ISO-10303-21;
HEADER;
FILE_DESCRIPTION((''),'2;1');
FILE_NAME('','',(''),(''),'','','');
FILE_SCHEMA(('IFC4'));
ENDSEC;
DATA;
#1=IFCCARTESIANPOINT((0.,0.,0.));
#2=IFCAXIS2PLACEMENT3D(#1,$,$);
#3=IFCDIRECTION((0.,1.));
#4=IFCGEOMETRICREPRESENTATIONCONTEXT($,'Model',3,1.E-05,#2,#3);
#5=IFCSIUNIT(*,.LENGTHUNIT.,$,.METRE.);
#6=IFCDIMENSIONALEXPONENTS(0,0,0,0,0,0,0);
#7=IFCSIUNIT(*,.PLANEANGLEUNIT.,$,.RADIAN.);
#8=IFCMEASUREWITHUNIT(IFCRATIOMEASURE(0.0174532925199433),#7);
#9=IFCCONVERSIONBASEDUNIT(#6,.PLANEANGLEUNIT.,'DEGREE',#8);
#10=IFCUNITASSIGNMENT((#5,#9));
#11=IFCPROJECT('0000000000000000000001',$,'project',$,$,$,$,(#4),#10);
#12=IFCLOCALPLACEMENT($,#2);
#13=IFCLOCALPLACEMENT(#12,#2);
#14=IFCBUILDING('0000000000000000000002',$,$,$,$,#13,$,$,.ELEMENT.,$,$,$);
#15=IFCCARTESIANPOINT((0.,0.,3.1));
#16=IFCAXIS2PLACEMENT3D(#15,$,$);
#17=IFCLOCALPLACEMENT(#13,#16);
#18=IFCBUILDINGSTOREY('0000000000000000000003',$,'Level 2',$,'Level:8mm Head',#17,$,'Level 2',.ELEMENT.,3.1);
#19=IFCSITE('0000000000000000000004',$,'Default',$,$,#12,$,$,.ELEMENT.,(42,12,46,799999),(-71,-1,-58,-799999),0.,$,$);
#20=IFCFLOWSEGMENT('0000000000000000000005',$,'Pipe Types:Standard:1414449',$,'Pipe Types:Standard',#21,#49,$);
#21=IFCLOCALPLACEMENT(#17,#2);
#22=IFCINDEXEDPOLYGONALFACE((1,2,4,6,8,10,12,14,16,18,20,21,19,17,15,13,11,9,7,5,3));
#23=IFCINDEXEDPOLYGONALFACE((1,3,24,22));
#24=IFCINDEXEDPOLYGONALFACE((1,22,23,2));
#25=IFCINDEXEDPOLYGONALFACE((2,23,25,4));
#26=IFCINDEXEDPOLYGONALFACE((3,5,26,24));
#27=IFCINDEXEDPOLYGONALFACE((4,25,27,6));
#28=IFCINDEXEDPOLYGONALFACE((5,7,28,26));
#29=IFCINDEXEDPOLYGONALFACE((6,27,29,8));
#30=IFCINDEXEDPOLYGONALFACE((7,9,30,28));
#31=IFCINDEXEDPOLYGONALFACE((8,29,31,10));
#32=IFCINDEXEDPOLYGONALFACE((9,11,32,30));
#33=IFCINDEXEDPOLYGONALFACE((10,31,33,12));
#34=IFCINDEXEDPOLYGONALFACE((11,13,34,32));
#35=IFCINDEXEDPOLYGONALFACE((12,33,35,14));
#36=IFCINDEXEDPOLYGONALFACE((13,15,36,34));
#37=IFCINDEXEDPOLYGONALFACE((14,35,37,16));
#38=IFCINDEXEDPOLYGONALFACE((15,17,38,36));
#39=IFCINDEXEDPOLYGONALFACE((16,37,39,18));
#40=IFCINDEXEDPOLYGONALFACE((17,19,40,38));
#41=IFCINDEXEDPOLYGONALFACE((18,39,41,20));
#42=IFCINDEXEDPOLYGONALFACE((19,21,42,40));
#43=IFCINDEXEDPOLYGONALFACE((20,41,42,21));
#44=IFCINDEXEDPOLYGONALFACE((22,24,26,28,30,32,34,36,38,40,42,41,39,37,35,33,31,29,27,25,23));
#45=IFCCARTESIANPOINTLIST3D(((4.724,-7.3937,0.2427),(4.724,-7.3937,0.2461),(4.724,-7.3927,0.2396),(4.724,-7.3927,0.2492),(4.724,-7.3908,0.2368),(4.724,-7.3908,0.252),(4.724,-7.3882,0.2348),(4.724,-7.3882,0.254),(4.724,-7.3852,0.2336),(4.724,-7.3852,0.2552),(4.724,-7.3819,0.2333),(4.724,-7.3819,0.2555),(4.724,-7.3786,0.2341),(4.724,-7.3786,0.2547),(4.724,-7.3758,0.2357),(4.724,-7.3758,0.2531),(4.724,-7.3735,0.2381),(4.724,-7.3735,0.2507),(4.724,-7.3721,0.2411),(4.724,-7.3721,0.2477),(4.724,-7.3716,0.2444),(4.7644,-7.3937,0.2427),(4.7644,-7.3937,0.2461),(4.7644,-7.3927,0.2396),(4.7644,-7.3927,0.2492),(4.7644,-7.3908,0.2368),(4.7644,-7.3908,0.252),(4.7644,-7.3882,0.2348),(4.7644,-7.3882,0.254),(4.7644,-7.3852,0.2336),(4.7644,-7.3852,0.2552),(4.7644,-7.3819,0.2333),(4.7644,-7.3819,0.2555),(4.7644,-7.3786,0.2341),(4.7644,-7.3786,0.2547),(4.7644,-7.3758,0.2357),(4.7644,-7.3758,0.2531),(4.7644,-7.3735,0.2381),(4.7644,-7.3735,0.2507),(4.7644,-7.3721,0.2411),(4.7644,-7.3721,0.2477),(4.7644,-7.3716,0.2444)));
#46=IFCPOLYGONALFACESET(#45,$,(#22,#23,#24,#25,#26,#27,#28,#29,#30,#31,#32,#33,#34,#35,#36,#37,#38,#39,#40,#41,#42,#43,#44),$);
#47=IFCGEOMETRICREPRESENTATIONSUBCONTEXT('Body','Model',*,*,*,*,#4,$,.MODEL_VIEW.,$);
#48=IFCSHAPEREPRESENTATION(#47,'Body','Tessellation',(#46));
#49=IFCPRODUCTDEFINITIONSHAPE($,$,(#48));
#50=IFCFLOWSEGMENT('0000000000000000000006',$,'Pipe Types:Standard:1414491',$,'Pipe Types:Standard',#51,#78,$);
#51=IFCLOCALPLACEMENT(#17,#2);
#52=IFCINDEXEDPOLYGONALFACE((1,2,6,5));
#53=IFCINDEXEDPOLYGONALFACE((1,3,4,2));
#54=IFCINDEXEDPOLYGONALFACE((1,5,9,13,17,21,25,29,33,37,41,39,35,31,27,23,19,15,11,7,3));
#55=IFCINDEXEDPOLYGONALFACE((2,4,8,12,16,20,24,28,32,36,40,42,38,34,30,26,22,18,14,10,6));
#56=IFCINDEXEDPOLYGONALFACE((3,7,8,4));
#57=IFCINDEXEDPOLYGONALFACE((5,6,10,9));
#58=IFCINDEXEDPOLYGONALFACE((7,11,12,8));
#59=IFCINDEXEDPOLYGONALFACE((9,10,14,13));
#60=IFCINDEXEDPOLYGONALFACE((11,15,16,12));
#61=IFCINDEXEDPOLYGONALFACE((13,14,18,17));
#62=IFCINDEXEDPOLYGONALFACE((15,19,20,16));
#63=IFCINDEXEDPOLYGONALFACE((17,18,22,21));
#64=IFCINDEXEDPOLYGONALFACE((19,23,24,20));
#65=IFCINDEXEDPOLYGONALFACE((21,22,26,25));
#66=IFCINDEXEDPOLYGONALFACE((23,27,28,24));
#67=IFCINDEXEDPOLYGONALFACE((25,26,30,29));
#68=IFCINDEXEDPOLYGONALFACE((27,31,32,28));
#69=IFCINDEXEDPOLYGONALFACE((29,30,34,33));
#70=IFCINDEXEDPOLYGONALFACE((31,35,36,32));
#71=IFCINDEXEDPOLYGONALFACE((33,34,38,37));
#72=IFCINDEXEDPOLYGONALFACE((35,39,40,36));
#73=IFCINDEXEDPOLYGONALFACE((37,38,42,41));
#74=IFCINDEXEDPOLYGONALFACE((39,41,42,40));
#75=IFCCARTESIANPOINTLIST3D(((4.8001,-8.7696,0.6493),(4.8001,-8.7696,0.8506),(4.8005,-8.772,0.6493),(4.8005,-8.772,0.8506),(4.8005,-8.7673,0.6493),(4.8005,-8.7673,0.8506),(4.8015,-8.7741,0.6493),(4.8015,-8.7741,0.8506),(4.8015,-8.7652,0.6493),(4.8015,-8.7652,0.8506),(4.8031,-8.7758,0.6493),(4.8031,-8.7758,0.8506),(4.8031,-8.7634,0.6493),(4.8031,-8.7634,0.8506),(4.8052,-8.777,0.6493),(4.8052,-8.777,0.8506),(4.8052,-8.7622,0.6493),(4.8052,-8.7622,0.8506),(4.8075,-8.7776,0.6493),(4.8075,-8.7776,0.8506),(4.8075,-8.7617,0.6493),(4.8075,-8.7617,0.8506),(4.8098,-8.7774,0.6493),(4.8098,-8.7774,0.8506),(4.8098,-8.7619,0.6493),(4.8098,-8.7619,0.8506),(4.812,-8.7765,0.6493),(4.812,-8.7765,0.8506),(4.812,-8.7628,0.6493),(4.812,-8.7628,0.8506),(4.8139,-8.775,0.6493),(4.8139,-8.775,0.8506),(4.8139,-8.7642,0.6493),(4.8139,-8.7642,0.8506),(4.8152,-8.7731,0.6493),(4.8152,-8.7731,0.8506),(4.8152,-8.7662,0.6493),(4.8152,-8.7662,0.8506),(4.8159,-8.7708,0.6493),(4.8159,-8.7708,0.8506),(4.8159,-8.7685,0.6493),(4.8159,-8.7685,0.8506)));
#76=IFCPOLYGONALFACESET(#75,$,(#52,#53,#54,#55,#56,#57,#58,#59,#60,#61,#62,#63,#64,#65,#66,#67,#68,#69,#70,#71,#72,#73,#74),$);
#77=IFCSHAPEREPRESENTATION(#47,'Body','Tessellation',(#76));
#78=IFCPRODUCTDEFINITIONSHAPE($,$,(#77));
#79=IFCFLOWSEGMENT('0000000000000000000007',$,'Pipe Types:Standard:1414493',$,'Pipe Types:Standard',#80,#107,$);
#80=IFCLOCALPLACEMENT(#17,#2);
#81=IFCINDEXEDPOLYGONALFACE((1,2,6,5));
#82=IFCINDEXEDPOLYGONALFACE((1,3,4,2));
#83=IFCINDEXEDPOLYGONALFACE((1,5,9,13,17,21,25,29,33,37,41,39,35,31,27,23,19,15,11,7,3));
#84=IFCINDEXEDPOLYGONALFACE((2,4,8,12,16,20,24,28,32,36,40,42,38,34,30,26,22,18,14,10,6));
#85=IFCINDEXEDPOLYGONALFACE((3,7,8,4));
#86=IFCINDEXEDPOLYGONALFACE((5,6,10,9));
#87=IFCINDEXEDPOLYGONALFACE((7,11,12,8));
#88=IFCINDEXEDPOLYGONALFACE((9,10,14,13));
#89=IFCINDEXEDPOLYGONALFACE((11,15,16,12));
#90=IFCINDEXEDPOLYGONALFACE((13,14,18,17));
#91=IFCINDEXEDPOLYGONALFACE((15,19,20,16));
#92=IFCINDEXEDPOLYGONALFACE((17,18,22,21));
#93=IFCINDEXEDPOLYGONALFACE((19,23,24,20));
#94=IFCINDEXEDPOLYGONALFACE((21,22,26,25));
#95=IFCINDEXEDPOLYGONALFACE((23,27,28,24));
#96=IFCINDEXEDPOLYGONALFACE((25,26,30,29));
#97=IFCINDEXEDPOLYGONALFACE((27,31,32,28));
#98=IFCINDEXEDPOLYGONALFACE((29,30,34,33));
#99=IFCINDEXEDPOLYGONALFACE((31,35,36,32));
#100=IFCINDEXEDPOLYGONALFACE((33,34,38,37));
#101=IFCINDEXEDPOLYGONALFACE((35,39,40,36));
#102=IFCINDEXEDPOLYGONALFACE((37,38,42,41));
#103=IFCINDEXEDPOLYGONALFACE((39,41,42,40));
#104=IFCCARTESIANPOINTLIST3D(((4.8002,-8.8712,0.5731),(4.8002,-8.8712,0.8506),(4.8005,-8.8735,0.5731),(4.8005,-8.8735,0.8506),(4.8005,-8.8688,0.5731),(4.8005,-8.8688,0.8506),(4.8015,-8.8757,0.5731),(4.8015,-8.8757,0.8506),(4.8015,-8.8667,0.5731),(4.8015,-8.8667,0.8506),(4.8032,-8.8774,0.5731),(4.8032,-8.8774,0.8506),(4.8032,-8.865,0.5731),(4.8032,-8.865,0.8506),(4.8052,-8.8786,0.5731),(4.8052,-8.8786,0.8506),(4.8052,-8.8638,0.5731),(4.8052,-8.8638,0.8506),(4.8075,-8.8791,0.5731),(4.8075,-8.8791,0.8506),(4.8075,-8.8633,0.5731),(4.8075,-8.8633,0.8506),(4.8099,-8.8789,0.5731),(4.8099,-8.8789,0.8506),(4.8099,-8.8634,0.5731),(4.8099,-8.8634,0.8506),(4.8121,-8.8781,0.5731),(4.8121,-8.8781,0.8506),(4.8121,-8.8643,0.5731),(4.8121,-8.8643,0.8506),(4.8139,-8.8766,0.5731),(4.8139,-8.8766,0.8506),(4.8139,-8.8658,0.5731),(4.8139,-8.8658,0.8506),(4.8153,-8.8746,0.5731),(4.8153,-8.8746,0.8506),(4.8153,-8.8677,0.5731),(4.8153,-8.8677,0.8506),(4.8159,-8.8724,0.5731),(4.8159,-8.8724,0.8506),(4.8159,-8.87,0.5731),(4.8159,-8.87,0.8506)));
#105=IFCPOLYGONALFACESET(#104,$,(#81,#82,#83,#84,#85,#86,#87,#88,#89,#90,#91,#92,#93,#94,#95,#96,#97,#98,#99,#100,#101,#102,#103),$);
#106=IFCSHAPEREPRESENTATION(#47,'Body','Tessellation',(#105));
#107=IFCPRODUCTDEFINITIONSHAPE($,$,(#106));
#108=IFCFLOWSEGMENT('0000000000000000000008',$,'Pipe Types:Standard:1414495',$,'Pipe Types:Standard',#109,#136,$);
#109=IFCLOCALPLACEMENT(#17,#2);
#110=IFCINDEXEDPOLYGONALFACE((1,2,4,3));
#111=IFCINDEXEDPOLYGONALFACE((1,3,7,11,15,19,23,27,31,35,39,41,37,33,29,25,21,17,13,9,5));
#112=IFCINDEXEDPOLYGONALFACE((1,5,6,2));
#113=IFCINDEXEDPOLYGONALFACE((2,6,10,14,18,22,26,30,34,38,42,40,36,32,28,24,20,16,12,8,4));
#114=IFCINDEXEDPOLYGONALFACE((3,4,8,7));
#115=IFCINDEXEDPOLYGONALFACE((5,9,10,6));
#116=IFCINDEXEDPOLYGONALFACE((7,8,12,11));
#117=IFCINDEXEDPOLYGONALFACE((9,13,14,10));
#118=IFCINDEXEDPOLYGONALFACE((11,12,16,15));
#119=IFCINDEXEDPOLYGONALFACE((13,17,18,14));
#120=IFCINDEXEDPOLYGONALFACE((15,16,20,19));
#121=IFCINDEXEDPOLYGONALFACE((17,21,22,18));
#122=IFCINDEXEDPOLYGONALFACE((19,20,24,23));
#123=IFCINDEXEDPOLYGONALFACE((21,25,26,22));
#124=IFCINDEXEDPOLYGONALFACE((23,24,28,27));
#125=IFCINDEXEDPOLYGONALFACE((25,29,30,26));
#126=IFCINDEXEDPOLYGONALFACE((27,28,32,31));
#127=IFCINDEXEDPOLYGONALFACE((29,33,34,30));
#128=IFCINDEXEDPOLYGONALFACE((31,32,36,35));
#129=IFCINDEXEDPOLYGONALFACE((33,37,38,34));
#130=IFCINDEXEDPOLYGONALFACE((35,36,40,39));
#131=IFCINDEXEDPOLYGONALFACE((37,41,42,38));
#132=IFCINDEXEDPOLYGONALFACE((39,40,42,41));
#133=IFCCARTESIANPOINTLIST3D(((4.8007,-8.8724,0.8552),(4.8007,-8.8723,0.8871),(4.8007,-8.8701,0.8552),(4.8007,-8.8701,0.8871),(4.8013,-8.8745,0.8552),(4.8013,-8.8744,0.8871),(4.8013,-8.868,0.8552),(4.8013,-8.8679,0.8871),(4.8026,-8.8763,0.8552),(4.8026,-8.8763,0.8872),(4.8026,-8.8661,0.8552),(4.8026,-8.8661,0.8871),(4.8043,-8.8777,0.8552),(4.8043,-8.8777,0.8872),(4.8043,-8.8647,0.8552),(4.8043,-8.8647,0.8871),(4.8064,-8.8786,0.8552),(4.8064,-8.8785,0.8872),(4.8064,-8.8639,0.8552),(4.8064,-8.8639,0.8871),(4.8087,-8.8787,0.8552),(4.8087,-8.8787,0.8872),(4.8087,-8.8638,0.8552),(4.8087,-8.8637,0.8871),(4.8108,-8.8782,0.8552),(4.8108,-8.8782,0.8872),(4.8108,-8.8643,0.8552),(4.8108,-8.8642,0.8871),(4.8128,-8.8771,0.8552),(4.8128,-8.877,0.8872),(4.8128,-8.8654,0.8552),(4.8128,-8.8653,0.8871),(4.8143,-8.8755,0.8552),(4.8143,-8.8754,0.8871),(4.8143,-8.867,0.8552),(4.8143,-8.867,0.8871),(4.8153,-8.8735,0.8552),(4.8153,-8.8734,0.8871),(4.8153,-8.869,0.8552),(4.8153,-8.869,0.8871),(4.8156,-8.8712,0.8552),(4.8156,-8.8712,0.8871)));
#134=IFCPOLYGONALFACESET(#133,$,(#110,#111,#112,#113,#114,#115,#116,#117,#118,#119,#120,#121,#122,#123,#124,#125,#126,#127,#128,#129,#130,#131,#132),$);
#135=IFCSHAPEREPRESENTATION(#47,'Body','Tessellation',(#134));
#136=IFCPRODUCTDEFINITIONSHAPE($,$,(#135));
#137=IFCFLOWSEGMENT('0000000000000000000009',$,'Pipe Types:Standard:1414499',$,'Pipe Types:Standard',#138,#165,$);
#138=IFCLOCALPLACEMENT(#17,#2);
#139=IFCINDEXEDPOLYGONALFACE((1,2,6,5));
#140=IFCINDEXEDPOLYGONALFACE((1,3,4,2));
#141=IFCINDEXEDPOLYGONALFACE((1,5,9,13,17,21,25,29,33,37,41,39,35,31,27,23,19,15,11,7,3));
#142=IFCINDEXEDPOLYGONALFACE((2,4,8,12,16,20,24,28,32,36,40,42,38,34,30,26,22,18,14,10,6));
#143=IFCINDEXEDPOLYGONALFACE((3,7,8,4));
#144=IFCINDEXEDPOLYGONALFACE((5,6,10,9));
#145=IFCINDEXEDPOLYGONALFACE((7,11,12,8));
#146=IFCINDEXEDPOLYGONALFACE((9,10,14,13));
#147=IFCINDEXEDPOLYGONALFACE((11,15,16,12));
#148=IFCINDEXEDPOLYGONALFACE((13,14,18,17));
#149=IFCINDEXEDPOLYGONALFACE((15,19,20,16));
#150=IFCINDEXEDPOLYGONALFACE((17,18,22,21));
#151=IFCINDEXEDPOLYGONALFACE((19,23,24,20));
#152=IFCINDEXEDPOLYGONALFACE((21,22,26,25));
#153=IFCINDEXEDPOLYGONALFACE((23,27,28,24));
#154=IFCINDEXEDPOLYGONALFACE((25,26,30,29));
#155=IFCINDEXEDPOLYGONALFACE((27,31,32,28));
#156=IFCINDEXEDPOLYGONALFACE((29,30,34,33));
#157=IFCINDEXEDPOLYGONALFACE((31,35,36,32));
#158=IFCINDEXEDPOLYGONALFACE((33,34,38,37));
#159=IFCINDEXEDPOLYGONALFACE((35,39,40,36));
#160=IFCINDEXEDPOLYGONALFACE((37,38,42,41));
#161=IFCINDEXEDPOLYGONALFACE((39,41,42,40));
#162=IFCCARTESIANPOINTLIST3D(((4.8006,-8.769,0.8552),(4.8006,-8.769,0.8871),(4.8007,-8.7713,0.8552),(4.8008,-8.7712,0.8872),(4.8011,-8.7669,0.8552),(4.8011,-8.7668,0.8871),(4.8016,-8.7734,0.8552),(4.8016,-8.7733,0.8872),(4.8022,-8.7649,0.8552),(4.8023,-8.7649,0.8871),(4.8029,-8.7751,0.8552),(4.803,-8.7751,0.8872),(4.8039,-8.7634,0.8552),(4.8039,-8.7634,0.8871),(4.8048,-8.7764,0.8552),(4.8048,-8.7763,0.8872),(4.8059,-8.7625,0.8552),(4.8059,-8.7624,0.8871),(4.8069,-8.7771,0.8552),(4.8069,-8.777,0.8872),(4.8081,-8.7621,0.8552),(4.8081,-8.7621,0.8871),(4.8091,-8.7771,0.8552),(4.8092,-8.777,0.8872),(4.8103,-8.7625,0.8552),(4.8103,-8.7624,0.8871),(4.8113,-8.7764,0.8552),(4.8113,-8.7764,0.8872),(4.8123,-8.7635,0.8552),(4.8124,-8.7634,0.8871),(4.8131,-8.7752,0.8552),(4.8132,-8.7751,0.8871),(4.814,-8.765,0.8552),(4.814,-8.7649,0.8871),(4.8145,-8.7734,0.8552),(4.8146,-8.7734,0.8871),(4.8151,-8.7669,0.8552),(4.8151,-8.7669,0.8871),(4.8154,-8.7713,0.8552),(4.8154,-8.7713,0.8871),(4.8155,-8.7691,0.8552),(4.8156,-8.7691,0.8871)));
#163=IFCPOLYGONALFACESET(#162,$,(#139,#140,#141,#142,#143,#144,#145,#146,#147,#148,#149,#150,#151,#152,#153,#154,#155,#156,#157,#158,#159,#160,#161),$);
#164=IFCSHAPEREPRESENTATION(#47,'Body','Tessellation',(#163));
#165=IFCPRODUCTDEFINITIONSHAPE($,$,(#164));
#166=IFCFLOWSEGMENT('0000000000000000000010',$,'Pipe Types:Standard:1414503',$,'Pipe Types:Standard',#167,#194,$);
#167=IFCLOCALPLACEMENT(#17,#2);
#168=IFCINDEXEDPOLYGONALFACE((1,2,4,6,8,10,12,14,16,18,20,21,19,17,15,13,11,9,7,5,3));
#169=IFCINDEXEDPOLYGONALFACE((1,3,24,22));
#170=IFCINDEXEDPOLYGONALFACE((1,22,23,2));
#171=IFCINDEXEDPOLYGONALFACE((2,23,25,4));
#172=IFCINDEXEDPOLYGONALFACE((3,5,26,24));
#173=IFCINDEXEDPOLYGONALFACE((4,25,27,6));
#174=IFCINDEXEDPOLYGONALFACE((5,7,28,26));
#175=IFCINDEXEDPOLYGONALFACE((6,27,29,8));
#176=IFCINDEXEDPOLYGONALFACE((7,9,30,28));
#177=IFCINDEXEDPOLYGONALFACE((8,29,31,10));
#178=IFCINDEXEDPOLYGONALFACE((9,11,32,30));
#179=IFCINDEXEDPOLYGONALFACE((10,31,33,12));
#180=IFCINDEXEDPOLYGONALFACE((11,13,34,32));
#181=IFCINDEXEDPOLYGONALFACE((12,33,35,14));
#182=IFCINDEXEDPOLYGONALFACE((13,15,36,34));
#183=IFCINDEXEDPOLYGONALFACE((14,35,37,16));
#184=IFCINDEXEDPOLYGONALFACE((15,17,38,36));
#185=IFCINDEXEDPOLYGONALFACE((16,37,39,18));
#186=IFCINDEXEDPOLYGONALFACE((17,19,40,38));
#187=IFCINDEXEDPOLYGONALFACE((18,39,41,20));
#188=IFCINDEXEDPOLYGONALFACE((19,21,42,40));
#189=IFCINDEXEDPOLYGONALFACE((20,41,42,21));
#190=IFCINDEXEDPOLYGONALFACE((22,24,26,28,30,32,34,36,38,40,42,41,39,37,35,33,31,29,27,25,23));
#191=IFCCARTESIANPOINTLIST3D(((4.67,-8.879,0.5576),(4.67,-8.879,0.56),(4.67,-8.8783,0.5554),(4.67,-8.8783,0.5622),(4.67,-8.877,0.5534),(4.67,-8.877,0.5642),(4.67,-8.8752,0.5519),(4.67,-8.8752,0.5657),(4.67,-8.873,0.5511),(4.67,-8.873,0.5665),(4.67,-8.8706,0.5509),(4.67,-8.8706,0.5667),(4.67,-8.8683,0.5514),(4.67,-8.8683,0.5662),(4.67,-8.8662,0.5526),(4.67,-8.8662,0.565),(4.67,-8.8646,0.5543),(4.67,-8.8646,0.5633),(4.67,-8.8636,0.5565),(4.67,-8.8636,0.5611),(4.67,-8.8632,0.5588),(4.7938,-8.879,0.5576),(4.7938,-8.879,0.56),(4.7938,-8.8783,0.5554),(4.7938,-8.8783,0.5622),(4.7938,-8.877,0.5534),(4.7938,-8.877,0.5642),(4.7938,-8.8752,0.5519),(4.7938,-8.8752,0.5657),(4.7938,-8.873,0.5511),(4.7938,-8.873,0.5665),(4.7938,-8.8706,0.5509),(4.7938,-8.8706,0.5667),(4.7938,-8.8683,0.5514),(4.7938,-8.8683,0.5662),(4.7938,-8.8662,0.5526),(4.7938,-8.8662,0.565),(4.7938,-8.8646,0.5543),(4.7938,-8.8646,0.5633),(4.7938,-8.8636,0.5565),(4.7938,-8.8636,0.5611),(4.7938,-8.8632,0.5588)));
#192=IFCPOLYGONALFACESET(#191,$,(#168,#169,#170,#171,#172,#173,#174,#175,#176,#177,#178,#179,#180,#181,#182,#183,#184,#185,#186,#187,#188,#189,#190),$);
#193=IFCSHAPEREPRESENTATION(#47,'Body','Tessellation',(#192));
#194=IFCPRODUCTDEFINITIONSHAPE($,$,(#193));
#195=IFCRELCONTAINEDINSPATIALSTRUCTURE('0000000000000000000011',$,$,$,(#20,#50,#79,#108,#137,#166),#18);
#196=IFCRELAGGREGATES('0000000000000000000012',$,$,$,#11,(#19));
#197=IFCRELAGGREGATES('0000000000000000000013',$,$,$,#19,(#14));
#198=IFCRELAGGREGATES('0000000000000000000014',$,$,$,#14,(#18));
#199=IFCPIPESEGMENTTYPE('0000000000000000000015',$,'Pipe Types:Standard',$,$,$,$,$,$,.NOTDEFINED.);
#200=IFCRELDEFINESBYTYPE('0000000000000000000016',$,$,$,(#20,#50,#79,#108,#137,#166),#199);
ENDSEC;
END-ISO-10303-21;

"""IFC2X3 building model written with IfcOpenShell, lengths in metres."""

from ifc_helpers import new_model, entity, si_unit, converted_unit, direction, frame, frame_2d, origin, origin_2d_with_axis, place, context, subcontext, project, spatial, circle, extrude, type_object, element, save


model = new_model("IFC2X3")

# Units and contexts
model_context = context("Model", 3, precision=1e-05, world=origin(), true_north=direction((0.0, 1.0)))
body_context = subcontext(model_context, "Body", "Model", "MODEL_VIEW")
ifc_project = project(units=[si_unit("LENGTHUNIT", "METRE"), converted_unit("PLANEANGLEUNIT", "DEGREE", entity("IfcRatioMeasure", 0.0174532925199433), si_unit("PLANEANGLEUNIT", "RADIAN"), dimensions=[0, 0, 0, 0, 0, 0, 0])], contexts=[model_context])

# Site, building, storey
site_placement = place(None, origin())
site = spatial("IfcSite", under=ifc_project, at=site_placement, Name="Default", CompositionType="ELEMENT", RefLatitude=(42, 12, 46, 799999), RefLongitude=(-71, -1, -58, -799999), RefElevation=0.0)
building_placement = place(site_placement, origin())
building = spatial("IfcBuilding", under=site, at=building_placement, CompositionType="ELEMENT")
storey_placement = place(building_placement, frame((0.0, 0.0, 3.1)))
storey = spatial("IfcBuildingStorey", under=building, at=storey_placement, Name="Level 2", ObjectType="Level:8mm Head", LongName="Level 2", CompositionType="ELEMENT", Elevation=3.1)

# Flow segments
pipe_segment_type = type_object("IfcPipeSegmentType", Name="Pipe Types:Standard", PredefinedType="NOTDEFINED")
flow_segment_1_placement = place(storey_placement, origin())
element("IfcFlowSegment", 1, at=flow_segment_1_placement, inside=storey, type_object=pipe_segment_type, Name="Pipe Types:Standard:1414449", ObjectType="Pipe Types:Standard", context=body_context, shape_type="SweptSolid", body=[
    extrude(circle(Radius=0.0111, at=frame_2d((0.0, 0.0), x_axis=(1.0, 0.0))), frame((4.724, -7.3827, 0.2444), z_axis=(1.0, 0.0, 0.0), x_axis=(0.0, 1.0, 0.0)), (0.0, 0.0, 1.0), 0.0405),
])
flow_segment_2_placement = place(storey_placement, origin())
element("IfcFlowSegment", 2, at=flow_segment_2_placement, inside=storey, type_object=pipe_segment_type, Name="Pipe Types:Standard:1414491", ObjectType="Pipe Types:Standard", context=body_context, shape_type="SweptSolid", body=[
    extrude(circle(Radius=0.0079, at=frame_2d((0.0, 0.0), x_axis=(1.0, 0.0))), frame((4.8081, -8.7696, 0.6493), z_axis=(0.0, 0.0, 1.0), x_axis=(-1.0, 0.0, 0.0)), (0.0, 0.0, 1.0), 0.2013),
])
flow_segment_3_placement = place(storey_placement, origin())
element("IfcFlowSegment", 3, at=flow_segment_3_placement, inside=storey, type_object=pipe_segment_type, Name="Pipe Types:Standard:1414493", ObjectType="Pipe Types:Standard", context=body_context, shape_type="SweptSolid", body=[
    extrude(circle(Radius=0.0079, at=origin_2d_with_axis()), frame((4.8081, -8.8712, 0.5731), z_axis=(0.0, 0.0, 1.0), x_axis=(-1.0, 0.0, 0.0)), (0.0, 0.0, 1.0), 0.2775),
])
flow_segment_4_placement = place(storey_placement, origin())
element("IfcFlowSegment", 4, at=flow_segment_4_placement, inside=storey, type_object=pipe_segment_type, Name="Pipe Types:Standard:1414495", ObjectType="Pipe Types:Standard", context=body_context, shape_type="SweptSolid", body=[
    extrude(circle(Radius=0.0075, at=origin_2d_with_axis()), frame((4.8081, -8.8712, 0.8552), z_axis=(0.0, 0.001852, 0.999998), x_axis=(1.0, 0.0, 0.0)), (0.0, 0.0, 1.0), 0.032),
])
flow_segment_5_placement = place(storey_placement, origin())
element("IfcFlowSegment", 5, at=flow_segment_5_placement, inside=storey, type_object=pipe_segment_type, Name="Pipe Types:Standard:1414499", ObjectType="Pipe Types:Standard", context=body_context, shape_type="SweptSolid", body=[
    extrude(circle(Radius=0.0075, at=frame_2d((0.0, 0.0), x_axis=(1.0, 0.0))), frame((4.8081, -8.7696, 0.8552), z_axis=(0.001081, 0.001852, 0.999998), x_axis=(0.863538, -0.504283, 0.0)), (0.0, 0.0, 1.0), 0.032),
])
flow_segment_6_placement = place(storey_placement, origin())
element("IfcFlowSegment", 6, at=flow_segment_6_placement, inside=storey, type_object=pipe_segment_type, Name="Pipe Types:Standard:1414503", ObjectType="Pipe Types:Standard", context=body_context, shape_type="SweptSolid", body=[
    extrude(circle(Radius=0.0079, at=frame_2d((0.0, 0.0), x_axis=(1.0, 0.0))), frame((4.67, -8.8712, 0.5588), z_axis=(1.0, 0.0, 0.0), x_axis=(0.0, 1.0, 0.0)), (0.0, 0.0, 1.0), 0.1238),
])

save(model, "model.ifc")
